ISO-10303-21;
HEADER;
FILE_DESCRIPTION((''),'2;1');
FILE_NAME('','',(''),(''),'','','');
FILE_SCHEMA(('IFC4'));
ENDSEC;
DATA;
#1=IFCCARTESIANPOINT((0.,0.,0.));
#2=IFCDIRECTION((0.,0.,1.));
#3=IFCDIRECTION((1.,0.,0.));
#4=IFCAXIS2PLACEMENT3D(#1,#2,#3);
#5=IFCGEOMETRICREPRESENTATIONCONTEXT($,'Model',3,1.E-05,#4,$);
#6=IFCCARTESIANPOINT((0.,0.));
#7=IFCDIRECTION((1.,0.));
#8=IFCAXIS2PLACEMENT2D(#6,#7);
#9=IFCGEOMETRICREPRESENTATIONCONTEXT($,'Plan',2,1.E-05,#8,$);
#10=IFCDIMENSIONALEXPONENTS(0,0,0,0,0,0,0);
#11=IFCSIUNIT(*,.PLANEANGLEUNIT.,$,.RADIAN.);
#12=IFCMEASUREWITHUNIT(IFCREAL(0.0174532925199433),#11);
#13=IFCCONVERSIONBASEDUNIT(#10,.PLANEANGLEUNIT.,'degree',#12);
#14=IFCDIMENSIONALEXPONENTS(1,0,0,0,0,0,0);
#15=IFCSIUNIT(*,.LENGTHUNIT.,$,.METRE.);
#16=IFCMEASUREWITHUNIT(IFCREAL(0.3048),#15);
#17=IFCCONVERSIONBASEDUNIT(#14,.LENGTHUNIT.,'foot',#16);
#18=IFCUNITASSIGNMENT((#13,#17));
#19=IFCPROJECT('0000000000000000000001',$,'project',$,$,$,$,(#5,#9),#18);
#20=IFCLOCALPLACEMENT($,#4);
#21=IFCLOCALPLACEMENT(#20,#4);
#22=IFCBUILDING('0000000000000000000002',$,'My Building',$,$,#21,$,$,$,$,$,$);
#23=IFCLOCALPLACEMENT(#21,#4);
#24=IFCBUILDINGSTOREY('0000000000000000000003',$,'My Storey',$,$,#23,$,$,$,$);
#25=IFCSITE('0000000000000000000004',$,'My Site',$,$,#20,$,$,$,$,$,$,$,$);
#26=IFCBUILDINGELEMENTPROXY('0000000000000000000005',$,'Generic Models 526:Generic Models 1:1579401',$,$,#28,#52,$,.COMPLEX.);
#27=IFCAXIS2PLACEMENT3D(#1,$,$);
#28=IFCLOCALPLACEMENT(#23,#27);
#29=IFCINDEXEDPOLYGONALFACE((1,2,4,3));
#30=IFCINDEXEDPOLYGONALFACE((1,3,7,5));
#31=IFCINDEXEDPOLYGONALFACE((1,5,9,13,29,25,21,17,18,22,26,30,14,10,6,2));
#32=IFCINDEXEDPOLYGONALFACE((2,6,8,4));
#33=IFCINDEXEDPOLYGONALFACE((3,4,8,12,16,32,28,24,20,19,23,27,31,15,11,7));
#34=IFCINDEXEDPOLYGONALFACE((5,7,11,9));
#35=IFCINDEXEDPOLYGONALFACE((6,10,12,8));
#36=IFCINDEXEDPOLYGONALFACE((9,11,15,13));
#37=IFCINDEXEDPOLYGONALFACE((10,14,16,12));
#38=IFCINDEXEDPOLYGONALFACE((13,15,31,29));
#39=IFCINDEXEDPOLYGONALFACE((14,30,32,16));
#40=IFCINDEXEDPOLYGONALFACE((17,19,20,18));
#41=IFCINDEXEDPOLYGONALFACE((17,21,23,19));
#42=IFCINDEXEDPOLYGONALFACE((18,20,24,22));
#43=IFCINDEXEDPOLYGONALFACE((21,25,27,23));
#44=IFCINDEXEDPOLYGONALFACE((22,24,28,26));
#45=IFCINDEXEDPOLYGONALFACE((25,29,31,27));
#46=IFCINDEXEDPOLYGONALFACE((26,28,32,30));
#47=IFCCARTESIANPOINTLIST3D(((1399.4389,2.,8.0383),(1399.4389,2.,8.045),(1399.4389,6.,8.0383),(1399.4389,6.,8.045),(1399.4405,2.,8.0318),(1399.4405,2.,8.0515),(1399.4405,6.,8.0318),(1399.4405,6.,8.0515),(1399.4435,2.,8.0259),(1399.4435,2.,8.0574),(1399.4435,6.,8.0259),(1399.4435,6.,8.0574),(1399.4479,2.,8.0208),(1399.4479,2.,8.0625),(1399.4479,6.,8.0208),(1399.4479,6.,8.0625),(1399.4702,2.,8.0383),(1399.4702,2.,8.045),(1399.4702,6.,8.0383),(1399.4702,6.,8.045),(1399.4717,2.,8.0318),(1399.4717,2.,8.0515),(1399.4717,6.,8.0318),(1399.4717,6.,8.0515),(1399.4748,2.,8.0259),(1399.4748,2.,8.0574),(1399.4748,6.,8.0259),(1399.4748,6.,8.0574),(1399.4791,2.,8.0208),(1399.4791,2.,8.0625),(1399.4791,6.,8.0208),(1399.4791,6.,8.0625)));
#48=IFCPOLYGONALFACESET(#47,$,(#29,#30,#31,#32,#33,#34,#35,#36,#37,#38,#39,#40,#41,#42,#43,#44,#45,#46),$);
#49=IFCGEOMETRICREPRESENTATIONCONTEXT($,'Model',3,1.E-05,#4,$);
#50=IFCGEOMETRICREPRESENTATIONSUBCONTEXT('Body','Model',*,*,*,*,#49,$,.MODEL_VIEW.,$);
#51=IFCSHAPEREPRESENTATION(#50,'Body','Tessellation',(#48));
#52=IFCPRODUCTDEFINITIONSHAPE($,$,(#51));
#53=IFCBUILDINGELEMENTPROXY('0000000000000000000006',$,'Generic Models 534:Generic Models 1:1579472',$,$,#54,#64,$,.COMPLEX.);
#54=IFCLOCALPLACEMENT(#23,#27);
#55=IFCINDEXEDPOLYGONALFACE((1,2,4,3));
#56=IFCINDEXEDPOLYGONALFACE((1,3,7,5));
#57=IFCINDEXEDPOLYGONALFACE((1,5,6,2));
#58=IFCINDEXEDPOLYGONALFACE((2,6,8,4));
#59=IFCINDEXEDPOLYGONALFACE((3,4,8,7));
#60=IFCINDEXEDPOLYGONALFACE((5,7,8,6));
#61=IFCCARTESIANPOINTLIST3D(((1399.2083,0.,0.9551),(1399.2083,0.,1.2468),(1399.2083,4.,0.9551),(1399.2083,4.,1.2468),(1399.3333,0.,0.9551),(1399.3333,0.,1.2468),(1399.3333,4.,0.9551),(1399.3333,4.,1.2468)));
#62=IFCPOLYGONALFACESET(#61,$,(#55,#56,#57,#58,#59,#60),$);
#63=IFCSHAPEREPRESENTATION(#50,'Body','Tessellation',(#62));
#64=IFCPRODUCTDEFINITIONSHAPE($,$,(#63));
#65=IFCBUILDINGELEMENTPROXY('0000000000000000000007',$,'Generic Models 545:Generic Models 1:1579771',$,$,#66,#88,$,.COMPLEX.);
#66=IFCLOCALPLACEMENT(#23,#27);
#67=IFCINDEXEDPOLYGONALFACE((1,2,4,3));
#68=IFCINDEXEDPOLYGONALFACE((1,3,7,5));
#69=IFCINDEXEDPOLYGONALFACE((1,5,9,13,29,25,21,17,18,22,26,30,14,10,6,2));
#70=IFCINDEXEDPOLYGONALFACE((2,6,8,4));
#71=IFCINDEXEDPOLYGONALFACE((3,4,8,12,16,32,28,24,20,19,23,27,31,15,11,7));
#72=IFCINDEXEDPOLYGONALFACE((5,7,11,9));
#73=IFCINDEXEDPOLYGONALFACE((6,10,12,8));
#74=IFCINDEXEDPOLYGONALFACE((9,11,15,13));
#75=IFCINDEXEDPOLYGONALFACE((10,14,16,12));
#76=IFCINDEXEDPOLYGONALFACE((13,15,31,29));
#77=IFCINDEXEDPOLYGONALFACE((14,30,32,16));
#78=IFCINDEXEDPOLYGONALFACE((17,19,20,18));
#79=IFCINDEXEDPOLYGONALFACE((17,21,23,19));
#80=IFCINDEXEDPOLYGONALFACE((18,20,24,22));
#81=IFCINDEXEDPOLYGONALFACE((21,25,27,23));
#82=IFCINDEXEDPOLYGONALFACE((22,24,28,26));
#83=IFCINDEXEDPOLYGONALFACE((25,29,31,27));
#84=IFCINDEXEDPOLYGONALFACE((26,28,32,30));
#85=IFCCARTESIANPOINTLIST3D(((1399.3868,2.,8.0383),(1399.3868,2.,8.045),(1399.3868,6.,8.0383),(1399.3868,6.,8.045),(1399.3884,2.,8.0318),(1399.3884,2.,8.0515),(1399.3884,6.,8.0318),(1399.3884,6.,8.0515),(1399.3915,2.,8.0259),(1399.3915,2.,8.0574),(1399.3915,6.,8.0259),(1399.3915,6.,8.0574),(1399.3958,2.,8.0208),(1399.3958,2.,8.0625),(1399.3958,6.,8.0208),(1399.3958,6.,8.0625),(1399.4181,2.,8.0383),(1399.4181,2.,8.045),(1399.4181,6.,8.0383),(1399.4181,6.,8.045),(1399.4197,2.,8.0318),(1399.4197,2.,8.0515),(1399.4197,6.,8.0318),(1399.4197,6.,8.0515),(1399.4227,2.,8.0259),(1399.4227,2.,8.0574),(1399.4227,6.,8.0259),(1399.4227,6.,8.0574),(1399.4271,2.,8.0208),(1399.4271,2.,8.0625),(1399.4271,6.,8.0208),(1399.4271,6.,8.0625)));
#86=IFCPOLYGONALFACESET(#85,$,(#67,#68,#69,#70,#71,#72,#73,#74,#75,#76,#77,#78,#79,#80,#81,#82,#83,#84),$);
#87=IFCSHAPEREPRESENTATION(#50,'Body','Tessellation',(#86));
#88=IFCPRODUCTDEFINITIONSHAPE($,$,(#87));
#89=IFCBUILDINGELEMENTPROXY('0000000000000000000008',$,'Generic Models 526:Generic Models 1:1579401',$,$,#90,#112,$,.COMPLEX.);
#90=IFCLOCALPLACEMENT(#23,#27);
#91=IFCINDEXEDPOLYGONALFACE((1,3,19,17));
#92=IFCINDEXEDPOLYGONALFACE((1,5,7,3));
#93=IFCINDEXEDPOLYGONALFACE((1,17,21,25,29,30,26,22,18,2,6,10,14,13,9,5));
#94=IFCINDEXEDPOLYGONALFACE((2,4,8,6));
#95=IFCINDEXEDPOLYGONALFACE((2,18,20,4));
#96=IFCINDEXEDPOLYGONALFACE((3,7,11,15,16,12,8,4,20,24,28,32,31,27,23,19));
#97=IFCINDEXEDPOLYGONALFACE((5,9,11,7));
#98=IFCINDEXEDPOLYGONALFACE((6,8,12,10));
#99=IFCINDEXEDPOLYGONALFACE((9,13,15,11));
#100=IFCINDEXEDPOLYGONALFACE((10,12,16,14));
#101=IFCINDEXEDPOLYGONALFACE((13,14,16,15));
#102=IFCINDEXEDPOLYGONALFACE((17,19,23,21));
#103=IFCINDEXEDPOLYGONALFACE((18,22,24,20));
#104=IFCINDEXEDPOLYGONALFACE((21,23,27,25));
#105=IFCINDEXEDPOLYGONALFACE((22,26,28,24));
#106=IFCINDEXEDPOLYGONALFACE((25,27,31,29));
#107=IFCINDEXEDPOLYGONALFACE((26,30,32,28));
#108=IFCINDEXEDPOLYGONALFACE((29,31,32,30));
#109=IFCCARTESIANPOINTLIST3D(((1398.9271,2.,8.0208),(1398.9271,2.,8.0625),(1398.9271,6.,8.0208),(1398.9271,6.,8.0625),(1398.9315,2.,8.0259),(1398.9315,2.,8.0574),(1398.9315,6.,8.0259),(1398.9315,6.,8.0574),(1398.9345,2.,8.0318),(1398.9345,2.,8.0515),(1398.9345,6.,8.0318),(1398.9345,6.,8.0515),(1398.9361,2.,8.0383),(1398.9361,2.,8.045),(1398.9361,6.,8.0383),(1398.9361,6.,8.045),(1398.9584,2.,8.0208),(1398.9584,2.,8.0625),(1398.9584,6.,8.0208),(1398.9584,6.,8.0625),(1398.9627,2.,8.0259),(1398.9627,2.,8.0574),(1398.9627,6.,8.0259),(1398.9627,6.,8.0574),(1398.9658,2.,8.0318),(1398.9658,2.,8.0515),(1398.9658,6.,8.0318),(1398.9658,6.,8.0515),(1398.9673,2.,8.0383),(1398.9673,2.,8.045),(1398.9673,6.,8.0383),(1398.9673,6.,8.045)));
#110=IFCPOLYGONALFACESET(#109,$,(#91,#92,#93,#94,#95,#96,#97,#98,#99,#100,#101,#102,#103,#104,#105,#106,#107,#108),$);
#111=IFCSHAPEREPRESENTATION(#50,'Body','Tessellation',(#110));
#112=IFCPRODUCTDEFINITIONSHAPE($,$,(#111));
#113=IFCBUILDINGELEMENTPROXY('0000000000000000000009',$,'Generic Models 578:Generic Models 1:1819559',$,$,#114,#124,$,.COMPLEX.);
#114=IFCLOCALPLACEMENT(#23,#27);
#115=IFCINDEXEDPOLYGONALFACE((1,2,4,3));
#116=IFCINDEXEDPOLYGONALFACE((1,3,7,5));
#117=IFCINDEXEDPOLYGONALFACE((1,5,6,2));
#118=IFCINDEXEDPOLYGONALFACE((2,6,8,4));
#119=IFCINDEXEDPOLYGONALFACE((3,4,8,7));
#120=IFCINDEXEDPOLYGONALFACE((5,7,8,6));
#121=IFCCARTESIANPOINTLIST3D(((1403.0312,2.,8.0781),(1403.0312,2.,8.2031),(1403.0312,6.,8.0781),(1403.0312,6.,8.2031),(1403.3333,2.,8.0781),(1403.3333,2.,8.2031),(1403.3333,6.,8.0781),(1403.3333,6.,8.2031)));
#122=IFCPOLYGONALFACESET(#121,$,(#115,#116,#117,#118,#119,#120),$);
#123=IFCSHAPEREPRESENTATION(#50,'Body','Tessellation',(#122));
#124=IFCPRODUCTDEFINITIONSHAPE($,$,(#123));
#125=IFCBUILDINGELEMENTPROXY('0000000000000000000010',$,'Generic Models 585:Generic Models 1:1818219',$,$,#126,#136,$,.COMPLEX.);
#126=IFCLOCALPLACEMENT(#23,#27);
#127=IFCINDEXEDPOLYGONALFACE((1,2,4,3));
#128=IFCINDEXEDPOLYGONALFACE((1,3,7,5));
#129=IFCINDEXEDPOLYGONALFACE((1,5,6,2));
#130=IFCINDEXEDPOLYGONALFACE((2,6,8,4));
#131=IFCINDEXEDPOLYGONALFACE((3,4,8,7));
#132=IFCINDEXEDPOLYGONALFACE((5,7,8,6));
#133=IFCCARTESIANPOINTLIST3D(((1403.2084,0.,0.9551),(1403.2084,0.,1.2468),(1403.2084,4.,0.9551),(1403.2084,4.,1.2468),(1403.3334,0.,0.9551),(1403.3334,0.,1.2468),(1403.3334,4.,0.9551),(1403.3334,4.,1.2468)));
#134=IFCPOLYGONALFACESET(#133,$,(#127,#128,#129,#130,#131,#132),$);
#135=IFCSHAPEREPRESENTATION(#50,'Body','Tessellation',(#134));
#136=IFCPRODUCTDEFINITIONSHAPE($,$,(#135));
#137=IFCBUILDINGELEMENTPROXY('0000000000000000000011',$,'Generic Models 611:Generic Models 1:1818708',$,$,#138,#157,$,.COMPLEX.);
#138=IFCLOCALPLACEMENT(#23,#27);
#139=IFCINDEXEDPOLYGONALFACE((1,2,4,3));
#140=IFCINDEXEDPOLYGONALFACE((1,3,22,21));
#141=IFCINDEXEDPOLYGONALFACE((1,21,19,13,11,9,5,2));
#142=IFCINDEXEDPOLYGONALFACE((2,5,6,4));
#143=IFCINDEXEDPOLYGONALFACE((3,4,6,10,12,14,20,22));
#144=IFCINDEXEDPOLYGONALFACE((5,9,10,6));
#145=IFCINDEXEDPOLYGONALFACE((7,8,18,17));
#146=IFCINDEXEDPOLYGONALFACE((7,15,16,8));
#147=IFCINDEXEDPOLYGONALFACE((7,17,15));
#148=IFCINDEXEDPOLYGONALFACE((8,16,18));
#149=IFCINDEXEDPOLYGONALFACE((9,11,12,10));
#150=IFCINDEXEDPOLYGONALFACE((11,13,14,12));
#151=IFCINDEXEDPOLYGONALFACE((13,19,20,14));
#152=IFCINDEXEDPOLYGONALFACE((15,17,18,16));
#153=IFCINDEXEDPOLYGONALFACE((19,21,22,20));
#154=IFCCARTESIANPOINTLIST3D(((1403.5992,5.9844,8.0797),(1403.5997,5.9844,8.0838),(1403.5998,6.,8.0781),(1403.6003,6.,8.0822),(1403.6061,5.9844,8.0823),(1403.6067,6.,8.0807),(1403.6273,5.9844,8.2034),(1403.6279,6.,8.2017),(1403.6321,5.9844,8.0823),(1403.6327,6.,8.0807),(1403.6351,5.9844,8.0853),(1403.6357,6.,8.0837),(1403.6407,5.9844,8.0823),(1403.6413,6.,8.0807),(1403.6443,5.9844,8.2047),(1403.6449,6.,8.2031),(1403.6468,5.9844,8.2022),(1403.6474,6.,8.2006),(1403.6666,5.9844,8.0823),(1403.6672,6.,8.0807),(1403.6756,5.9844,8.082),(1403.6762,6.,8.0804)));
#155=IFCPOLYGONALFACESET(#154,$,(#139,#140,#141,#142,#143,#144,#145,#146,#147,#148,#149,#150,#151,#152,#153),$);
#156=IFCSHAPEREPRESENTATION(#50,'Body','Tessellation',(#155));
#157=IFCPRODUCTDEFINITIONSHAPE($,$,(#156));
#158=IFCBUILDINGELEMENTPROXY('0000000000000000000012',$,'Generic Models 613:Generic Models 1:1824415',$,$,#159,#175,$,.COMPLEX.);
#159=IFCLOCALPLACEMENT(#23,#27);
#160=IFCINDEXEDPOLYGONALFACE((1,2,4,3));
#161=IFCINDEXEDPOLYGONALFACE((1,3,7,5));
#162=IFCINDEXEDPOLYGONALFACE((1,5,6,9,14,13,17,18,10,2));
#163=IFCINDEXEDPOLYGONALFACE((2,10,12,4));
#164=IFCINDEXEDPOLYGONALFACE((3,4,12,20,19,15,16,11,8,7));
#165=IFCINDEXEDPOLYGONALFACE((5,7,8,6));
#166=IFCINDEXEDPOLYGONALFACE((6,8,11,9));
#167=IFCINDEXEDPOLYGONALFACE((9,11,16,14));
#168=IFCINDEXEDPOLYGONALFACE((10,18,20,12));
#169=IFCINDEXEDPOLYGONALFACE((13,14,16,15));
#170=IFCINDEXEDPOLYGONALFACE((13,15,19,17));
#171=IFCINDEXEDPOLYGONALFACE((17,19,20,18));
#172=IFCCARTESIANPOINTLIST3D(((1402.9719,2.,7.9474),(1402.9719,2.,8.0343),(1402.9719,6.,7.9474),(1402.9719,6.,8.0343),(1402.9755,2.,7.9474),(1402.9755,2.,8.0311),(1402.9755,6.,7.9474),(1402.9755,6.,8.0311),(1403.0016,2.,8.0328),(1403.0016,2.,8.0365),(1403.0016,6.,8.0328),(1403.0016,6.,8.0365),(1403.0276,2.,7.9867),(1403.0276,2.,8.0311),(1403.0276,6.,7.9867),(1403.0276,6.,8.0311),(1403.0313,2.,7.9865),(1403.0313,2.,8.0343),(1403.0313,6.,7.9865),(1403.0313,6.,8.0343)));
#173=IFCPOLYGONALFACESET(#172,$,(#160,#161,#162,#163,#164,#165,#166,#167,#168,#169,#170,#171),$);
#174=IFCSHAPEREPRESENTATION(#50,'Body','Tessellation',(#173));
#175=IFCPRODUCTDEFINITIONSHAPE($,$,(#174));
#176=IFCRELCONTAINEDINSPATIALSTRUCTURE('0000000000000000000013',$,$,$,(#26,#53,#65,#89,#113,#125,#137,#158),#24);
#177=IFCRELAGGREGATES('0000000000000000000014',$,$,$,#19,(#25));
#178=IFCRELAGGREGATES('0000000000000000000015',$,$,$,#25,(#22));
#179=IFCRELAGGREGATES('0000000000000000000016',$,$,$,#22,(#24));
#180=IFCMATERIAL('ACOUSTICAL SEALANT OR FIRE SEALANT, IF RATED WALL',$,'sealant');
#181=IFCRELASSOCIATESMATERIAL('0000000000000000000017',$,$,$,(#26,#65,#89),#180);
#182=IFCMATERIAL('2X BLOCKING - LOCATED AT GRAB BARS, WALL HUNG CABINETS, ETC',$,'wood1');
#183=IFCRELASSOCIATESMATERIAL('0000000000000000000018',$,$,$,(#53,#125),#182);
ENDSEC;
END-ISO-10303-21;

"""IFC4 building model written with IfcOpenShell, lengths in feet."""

from ifc_helpers import new_model, entity, si_unit, converted_unit, frame, origin_with_axes, origin_2d_with_axis, place, context, subcontext, project, spatial, polyline, outline, extrude, material, element, save


model = new_model("IFC4")

# Units and contexts
model_context_1 = context("Model", 3, precision=1e-05, world=origin_with_axes())
plan_context = context("Plan", 2, precision=1e-05, world=origin_2d_with_axis())
model_context_2 = context("Model", 3, precision=1e-05, world=origin_with_axes())
body_context = subcontext(model_context_2, "Body", "Model", "MODEL_VIEW")
ifc_project = project(units=[converted_unit("PLANEANGLEUNIT", "degree", entity("IfcReal", 0.0174532925199433), si_unit("PLANEANGLEUNIT", "RADIAN"), dimensions=[0, 0, 0, 0, 0, 0, 0]), converted_unit("LENGTHUNIT", "foot", entity("IfcReal", 0.3048), si_unit("LENGTHUNIT", "METRE"), dimensions=[1, 0, 0, 0, 0, 0, 0])], contexts=[model_context_1, plan_context])

# Site, building, storey
site_placement = place(None, origin_with_axes())
site = spatial("IfcSite", under=ifc_project, at=site_placement, Name="My Site")
building_placement = place(site_placement, origin_with_axes())
building = spatial("IfcBuilding", under=site, at=building_placement, Name="My Building")
storey_placement = place(building_placement, origin_with_axes())
storey = spatial("IfcBuildingStorey", under=building, at=storey_placement, Name="My Storey")

# Building element proxies
ifc_material_1 = material(Name="ACOUSTICAL SEALANT OR FIRE SEALANT, IF RATED WALL", Category="sealant")
proxy_1_placement = place(storey_placement, frame((1399.4389, 6.0, 8.0208), z_axis=(0.0, -1.0, 0.0), x_axis=(0.0, 0.0, 1.0)))
element("IfcBuildingElementProxy", 1, at=proxy_1_placement, inside=storey, material=ifc_material_1, Name="Generic Models 526:Generic Models 1:1579401", PredefinedType="COMPLEX", context=body_context, shape_type="SweptSolid", body=[
    extrude(outline(polyline([(0.0294, 0.0), (0.0074, 0.0221), (0.0007, 0.0216), (-0.0057, 0.0196), (-0.0114, 0.0161), (-0.0161, 0.0114), (-0.0196, 0.0057), (-0.0216, -0.0007), (-0.0221, -0.0073), (0.0, -0.0294), (0.0005, -0.0228), (0.0025, -0.0164), (0.006, -0.0107), (0.0107, -0.006), (0.0164, -0.0025), (0.0228, -0.0005), (0.0294, 0.0)])), frame((0.0208, -0.0194, 0.0), z_axis=(0.0, 0.0, -1.0), x_axis=(-0.707667, -0.706546, 0.0)), (0.0, 0.0, -1.0), 4.0),
])
ifc_material_2 = material(Name="2X BLOCKING - LOCATED AT GRAB BARS, WALL HUNG CABINETS, ETC", Category="wood1")
proxy_2_placement = place(storey_placement, frame((1399.2083, 4.0, 0.9551), z_axis=(0.0, -1.0, 0.0), x_axis=(0.0, 0.0, 1.0)))
element("IfcBuildingElementProxy", 2, at=proxy_2_placement, inside=storey, material=ifc_material_2, Name="Generic Models 534:Generic Models 1:1579472", PredefinedType="COMPLEX", context=body_context, shape_type="SweptSolid", body=[
    extrude(outline(polyline([(-0.1458, -0.0625), (0.1458, -0.0625), (0.1458, 0.0625), (-0.1458, 0.0625), (-0.1458, -0.0625)])), frame((0.1458, -0.0625, 0.0), z_axis=(0.0, 0.0, -1.0), x_axis=(1.0, 0.0, 0.0)), (0.0, 0.0, -1.0), 4.0),
])
proxy_3_placement = place(storey_placement, frame((1399.3868, 6.0, 8.0208), z_axis=(0.0, -1.0, 0.0), x_axis=(0.0, 0.0, 1.0)))
element("IfcBuildingElementProxy", 3, at=proxy_3_placement, inside=storey, material=ifc_material_1, Name="Generic Models 545:Generic Models 1:1579771", PredefinedType="COMPLEX", context=body_context, shape_type="SweptSolid", body=[
    extrude(outline(polyline([(0.0166, 0.0), (0.0115, 0.0043), (0.0076, 0.0097), (0.005, 0.0159), (0.0039, 0.0224), (0.0045, 0.0291), (-0.0207, 0.0106), (-0.0213, 0.004), (-0.0202, -0.0026), (-0.0176, -0.0088), (-0.0137, -0.0142), (-0.0086, -0.0185), (-0.0026, -0.0215), (0.0039, -0.023), (0.0291, -0.0045), (0.0226, -0.003), (0.0166, 0.0)])), frame((0.0208, -0.0194, 0.0), z_axis=(0.0, 0.0, -1.0), x_axis=(0.591192, -0.806531, 0.0)), (0.0, 0.0, -1.0), 4.0),
])
proxy_4_placement = place(storey_placement, frame((1398.9271, 6.0, 8.0208), z_axis=(0.0, -1.0, 0.0), x_axis=(0.0, 0.0, 1.0)))
element("IfcBuildingElementProxy", 4, at=proxy_4_placement, inside=storey, material=ifc_material_1, Name="Generic Models 526:Generic Models 1:1579401", PredefinedType="COMPLEX", context=body_context, shape_type="SweptSolid", body=[
    extrude(outline(polyline([(0.0216, 0.0), (0.0223, 0.0066), (0.001, 0.0294), (0.0002, 0.0228), (-0.002, 0.0165), (-0.0057, 0.0109), (-0.0105, 0.0064), (-0.0163, 0.0031), (-0.0228, 0.0012), (-0.0294, 0.0009), (-0.008, -0.0219), (-0.0014, -0.0216), (0.005, -0.0197), (0.0108, -0.0164), (0.0157, -0.0119), (0.0194, -0.0063), (0.0216, 0.0)])), frame((0.0208, -0.0208, 0.0), z_axis=(0.0, 0.0, -1.0), x_axis=(-0.729168, -0.684334, 0.0)), (0.0, 0.0, -1.0), 4.0),
])
proxy_5_placement = place(storey_placement, frame((1403.0312, 6.0, 8.0781), z_axis=(0.0, -1.0, 0.0), x_axis=(0.0, 0.0, 1.0)))
element("IfcBuildingElementProxy", 5, at=proxy_5_placement, inside=storey, Name="Generic Models 578:Generic Models 1:1819559", PredefinedType="COMPLEX", context=body_context, shape_type="SweptSolid", body=[
    extrude(outline(polyline([(-0.0625, -0.151), (0.0625, -0.151), (0.0625, 0.151), (-0.0625, 0.151), (-0.0625, -0.151)])), frame((0.0625, -0.151, 0.0), z_axis=(0.0, 0.0, -1.0), x_axis=(-1.0, 0.0, 0.0)), (0.0, 0.0, -1.0), 4.0),
])
proxy_6_placement = place(storey_placement, frame((1403.2084, 0.0, 0.9551), z_axis=(0.0, 0.0, 1.0), x_axis=(0.0, 1.0, 0.0)))
element("IfcBuildingElementProxy", 6, at=proxy_6_placement, inside=storey, material=ifc_material_2, Name="Generic Models 585:Generic Models 1:1818219", PredefinedType="COMPLEX", context=body_context, shape_type="SweptSolid", body=[
    extrude(outline(polyline([(-2.0, -0.0625), (2.0, -0.0625), (2.0, 0.0625), (-2.0, 0.0625), (-2.0, -0.0625)])), frame((2.0, -0.0625, 0.0), z_axis=(0.0, 0.0, -1.0), x_axis=(1.0, 0.0, 0.0)), (0.0, 0.0, -1.0), 0.2917),
])
proxy_7_placement = place(storey_placement, frame((1403.5977, 6.0, 8.0781), z_axis=(0.0, -1.0, 0.0), x_axis=(0.0, 0.0, 1.0)))
element("IfcBuildingElementProxy", 7, at=proxy_7_placement, inside=storey, Name="Generic Models 611:Generic Models 1:1818708", PredefinedType="COMPLEX", context=body_context, shape_type="SweptSolid", body=[
    extrude(outline(polyline([(-0.0327, -0.0018), (0.0437, -0.0018), (0.0347, -0.0013), (0.0088, -0.0005), (0.0033, 0.0027), (0.0002, -0.0002), (-0.0257, 0.0006), (-0.0321, 0.0023), (-0.0327, -0.0018)]), holes=[polyline([(0.0185, 0.1192), (-0.0009, 0.121), (0.0161, 0.1218), (0.0185, 0.1192)])]), frame((0.0028, -0.0348, 0.0), z_axis=(0.0, 0.0, 1.0), x_axis=(0.030379, -0.999538, 0.0)), (-0.034778, 0.104274, 0.99394), 0.0157),
])
proxy_8_placement = place(storey_placement, frame((1402.9719, 6.0, 7.9474), z_axis=(0.0, -1.0, 0.0), x_axis=(0.0, 0.0, 1.0)))
element("IfcBuildingElementProxy", 8, at=proxy_8_placement, inside=storey, Name="Generic Models 613:Generic Models 1:1824415", PredefinedType="COMPLEX", context=body_context, shape_type="SweptSolid", body=[
    extrude(outline(polyline([(-0.0243, 0.026), (0.0594, 0.026), (0.0594, 0.0297), (-0.0275, 0.0297), (-0.0296, 0.0), (-0.0275, -0.0297), (0.0203, -0.0297), (0.0201, -0.026), (-0.0243, -0.026), (-0.026, 0.0), (-0.0243, 0.026)])), frame((0.0594, -0.0297, 0.0), z_axis=(0.0, 0.0, -1.0), x_axis=(-1.0, 0.0, 0.0)), (0.0, 0.0, -1.0), 4.0),
])

save(model, "model.ifc")
